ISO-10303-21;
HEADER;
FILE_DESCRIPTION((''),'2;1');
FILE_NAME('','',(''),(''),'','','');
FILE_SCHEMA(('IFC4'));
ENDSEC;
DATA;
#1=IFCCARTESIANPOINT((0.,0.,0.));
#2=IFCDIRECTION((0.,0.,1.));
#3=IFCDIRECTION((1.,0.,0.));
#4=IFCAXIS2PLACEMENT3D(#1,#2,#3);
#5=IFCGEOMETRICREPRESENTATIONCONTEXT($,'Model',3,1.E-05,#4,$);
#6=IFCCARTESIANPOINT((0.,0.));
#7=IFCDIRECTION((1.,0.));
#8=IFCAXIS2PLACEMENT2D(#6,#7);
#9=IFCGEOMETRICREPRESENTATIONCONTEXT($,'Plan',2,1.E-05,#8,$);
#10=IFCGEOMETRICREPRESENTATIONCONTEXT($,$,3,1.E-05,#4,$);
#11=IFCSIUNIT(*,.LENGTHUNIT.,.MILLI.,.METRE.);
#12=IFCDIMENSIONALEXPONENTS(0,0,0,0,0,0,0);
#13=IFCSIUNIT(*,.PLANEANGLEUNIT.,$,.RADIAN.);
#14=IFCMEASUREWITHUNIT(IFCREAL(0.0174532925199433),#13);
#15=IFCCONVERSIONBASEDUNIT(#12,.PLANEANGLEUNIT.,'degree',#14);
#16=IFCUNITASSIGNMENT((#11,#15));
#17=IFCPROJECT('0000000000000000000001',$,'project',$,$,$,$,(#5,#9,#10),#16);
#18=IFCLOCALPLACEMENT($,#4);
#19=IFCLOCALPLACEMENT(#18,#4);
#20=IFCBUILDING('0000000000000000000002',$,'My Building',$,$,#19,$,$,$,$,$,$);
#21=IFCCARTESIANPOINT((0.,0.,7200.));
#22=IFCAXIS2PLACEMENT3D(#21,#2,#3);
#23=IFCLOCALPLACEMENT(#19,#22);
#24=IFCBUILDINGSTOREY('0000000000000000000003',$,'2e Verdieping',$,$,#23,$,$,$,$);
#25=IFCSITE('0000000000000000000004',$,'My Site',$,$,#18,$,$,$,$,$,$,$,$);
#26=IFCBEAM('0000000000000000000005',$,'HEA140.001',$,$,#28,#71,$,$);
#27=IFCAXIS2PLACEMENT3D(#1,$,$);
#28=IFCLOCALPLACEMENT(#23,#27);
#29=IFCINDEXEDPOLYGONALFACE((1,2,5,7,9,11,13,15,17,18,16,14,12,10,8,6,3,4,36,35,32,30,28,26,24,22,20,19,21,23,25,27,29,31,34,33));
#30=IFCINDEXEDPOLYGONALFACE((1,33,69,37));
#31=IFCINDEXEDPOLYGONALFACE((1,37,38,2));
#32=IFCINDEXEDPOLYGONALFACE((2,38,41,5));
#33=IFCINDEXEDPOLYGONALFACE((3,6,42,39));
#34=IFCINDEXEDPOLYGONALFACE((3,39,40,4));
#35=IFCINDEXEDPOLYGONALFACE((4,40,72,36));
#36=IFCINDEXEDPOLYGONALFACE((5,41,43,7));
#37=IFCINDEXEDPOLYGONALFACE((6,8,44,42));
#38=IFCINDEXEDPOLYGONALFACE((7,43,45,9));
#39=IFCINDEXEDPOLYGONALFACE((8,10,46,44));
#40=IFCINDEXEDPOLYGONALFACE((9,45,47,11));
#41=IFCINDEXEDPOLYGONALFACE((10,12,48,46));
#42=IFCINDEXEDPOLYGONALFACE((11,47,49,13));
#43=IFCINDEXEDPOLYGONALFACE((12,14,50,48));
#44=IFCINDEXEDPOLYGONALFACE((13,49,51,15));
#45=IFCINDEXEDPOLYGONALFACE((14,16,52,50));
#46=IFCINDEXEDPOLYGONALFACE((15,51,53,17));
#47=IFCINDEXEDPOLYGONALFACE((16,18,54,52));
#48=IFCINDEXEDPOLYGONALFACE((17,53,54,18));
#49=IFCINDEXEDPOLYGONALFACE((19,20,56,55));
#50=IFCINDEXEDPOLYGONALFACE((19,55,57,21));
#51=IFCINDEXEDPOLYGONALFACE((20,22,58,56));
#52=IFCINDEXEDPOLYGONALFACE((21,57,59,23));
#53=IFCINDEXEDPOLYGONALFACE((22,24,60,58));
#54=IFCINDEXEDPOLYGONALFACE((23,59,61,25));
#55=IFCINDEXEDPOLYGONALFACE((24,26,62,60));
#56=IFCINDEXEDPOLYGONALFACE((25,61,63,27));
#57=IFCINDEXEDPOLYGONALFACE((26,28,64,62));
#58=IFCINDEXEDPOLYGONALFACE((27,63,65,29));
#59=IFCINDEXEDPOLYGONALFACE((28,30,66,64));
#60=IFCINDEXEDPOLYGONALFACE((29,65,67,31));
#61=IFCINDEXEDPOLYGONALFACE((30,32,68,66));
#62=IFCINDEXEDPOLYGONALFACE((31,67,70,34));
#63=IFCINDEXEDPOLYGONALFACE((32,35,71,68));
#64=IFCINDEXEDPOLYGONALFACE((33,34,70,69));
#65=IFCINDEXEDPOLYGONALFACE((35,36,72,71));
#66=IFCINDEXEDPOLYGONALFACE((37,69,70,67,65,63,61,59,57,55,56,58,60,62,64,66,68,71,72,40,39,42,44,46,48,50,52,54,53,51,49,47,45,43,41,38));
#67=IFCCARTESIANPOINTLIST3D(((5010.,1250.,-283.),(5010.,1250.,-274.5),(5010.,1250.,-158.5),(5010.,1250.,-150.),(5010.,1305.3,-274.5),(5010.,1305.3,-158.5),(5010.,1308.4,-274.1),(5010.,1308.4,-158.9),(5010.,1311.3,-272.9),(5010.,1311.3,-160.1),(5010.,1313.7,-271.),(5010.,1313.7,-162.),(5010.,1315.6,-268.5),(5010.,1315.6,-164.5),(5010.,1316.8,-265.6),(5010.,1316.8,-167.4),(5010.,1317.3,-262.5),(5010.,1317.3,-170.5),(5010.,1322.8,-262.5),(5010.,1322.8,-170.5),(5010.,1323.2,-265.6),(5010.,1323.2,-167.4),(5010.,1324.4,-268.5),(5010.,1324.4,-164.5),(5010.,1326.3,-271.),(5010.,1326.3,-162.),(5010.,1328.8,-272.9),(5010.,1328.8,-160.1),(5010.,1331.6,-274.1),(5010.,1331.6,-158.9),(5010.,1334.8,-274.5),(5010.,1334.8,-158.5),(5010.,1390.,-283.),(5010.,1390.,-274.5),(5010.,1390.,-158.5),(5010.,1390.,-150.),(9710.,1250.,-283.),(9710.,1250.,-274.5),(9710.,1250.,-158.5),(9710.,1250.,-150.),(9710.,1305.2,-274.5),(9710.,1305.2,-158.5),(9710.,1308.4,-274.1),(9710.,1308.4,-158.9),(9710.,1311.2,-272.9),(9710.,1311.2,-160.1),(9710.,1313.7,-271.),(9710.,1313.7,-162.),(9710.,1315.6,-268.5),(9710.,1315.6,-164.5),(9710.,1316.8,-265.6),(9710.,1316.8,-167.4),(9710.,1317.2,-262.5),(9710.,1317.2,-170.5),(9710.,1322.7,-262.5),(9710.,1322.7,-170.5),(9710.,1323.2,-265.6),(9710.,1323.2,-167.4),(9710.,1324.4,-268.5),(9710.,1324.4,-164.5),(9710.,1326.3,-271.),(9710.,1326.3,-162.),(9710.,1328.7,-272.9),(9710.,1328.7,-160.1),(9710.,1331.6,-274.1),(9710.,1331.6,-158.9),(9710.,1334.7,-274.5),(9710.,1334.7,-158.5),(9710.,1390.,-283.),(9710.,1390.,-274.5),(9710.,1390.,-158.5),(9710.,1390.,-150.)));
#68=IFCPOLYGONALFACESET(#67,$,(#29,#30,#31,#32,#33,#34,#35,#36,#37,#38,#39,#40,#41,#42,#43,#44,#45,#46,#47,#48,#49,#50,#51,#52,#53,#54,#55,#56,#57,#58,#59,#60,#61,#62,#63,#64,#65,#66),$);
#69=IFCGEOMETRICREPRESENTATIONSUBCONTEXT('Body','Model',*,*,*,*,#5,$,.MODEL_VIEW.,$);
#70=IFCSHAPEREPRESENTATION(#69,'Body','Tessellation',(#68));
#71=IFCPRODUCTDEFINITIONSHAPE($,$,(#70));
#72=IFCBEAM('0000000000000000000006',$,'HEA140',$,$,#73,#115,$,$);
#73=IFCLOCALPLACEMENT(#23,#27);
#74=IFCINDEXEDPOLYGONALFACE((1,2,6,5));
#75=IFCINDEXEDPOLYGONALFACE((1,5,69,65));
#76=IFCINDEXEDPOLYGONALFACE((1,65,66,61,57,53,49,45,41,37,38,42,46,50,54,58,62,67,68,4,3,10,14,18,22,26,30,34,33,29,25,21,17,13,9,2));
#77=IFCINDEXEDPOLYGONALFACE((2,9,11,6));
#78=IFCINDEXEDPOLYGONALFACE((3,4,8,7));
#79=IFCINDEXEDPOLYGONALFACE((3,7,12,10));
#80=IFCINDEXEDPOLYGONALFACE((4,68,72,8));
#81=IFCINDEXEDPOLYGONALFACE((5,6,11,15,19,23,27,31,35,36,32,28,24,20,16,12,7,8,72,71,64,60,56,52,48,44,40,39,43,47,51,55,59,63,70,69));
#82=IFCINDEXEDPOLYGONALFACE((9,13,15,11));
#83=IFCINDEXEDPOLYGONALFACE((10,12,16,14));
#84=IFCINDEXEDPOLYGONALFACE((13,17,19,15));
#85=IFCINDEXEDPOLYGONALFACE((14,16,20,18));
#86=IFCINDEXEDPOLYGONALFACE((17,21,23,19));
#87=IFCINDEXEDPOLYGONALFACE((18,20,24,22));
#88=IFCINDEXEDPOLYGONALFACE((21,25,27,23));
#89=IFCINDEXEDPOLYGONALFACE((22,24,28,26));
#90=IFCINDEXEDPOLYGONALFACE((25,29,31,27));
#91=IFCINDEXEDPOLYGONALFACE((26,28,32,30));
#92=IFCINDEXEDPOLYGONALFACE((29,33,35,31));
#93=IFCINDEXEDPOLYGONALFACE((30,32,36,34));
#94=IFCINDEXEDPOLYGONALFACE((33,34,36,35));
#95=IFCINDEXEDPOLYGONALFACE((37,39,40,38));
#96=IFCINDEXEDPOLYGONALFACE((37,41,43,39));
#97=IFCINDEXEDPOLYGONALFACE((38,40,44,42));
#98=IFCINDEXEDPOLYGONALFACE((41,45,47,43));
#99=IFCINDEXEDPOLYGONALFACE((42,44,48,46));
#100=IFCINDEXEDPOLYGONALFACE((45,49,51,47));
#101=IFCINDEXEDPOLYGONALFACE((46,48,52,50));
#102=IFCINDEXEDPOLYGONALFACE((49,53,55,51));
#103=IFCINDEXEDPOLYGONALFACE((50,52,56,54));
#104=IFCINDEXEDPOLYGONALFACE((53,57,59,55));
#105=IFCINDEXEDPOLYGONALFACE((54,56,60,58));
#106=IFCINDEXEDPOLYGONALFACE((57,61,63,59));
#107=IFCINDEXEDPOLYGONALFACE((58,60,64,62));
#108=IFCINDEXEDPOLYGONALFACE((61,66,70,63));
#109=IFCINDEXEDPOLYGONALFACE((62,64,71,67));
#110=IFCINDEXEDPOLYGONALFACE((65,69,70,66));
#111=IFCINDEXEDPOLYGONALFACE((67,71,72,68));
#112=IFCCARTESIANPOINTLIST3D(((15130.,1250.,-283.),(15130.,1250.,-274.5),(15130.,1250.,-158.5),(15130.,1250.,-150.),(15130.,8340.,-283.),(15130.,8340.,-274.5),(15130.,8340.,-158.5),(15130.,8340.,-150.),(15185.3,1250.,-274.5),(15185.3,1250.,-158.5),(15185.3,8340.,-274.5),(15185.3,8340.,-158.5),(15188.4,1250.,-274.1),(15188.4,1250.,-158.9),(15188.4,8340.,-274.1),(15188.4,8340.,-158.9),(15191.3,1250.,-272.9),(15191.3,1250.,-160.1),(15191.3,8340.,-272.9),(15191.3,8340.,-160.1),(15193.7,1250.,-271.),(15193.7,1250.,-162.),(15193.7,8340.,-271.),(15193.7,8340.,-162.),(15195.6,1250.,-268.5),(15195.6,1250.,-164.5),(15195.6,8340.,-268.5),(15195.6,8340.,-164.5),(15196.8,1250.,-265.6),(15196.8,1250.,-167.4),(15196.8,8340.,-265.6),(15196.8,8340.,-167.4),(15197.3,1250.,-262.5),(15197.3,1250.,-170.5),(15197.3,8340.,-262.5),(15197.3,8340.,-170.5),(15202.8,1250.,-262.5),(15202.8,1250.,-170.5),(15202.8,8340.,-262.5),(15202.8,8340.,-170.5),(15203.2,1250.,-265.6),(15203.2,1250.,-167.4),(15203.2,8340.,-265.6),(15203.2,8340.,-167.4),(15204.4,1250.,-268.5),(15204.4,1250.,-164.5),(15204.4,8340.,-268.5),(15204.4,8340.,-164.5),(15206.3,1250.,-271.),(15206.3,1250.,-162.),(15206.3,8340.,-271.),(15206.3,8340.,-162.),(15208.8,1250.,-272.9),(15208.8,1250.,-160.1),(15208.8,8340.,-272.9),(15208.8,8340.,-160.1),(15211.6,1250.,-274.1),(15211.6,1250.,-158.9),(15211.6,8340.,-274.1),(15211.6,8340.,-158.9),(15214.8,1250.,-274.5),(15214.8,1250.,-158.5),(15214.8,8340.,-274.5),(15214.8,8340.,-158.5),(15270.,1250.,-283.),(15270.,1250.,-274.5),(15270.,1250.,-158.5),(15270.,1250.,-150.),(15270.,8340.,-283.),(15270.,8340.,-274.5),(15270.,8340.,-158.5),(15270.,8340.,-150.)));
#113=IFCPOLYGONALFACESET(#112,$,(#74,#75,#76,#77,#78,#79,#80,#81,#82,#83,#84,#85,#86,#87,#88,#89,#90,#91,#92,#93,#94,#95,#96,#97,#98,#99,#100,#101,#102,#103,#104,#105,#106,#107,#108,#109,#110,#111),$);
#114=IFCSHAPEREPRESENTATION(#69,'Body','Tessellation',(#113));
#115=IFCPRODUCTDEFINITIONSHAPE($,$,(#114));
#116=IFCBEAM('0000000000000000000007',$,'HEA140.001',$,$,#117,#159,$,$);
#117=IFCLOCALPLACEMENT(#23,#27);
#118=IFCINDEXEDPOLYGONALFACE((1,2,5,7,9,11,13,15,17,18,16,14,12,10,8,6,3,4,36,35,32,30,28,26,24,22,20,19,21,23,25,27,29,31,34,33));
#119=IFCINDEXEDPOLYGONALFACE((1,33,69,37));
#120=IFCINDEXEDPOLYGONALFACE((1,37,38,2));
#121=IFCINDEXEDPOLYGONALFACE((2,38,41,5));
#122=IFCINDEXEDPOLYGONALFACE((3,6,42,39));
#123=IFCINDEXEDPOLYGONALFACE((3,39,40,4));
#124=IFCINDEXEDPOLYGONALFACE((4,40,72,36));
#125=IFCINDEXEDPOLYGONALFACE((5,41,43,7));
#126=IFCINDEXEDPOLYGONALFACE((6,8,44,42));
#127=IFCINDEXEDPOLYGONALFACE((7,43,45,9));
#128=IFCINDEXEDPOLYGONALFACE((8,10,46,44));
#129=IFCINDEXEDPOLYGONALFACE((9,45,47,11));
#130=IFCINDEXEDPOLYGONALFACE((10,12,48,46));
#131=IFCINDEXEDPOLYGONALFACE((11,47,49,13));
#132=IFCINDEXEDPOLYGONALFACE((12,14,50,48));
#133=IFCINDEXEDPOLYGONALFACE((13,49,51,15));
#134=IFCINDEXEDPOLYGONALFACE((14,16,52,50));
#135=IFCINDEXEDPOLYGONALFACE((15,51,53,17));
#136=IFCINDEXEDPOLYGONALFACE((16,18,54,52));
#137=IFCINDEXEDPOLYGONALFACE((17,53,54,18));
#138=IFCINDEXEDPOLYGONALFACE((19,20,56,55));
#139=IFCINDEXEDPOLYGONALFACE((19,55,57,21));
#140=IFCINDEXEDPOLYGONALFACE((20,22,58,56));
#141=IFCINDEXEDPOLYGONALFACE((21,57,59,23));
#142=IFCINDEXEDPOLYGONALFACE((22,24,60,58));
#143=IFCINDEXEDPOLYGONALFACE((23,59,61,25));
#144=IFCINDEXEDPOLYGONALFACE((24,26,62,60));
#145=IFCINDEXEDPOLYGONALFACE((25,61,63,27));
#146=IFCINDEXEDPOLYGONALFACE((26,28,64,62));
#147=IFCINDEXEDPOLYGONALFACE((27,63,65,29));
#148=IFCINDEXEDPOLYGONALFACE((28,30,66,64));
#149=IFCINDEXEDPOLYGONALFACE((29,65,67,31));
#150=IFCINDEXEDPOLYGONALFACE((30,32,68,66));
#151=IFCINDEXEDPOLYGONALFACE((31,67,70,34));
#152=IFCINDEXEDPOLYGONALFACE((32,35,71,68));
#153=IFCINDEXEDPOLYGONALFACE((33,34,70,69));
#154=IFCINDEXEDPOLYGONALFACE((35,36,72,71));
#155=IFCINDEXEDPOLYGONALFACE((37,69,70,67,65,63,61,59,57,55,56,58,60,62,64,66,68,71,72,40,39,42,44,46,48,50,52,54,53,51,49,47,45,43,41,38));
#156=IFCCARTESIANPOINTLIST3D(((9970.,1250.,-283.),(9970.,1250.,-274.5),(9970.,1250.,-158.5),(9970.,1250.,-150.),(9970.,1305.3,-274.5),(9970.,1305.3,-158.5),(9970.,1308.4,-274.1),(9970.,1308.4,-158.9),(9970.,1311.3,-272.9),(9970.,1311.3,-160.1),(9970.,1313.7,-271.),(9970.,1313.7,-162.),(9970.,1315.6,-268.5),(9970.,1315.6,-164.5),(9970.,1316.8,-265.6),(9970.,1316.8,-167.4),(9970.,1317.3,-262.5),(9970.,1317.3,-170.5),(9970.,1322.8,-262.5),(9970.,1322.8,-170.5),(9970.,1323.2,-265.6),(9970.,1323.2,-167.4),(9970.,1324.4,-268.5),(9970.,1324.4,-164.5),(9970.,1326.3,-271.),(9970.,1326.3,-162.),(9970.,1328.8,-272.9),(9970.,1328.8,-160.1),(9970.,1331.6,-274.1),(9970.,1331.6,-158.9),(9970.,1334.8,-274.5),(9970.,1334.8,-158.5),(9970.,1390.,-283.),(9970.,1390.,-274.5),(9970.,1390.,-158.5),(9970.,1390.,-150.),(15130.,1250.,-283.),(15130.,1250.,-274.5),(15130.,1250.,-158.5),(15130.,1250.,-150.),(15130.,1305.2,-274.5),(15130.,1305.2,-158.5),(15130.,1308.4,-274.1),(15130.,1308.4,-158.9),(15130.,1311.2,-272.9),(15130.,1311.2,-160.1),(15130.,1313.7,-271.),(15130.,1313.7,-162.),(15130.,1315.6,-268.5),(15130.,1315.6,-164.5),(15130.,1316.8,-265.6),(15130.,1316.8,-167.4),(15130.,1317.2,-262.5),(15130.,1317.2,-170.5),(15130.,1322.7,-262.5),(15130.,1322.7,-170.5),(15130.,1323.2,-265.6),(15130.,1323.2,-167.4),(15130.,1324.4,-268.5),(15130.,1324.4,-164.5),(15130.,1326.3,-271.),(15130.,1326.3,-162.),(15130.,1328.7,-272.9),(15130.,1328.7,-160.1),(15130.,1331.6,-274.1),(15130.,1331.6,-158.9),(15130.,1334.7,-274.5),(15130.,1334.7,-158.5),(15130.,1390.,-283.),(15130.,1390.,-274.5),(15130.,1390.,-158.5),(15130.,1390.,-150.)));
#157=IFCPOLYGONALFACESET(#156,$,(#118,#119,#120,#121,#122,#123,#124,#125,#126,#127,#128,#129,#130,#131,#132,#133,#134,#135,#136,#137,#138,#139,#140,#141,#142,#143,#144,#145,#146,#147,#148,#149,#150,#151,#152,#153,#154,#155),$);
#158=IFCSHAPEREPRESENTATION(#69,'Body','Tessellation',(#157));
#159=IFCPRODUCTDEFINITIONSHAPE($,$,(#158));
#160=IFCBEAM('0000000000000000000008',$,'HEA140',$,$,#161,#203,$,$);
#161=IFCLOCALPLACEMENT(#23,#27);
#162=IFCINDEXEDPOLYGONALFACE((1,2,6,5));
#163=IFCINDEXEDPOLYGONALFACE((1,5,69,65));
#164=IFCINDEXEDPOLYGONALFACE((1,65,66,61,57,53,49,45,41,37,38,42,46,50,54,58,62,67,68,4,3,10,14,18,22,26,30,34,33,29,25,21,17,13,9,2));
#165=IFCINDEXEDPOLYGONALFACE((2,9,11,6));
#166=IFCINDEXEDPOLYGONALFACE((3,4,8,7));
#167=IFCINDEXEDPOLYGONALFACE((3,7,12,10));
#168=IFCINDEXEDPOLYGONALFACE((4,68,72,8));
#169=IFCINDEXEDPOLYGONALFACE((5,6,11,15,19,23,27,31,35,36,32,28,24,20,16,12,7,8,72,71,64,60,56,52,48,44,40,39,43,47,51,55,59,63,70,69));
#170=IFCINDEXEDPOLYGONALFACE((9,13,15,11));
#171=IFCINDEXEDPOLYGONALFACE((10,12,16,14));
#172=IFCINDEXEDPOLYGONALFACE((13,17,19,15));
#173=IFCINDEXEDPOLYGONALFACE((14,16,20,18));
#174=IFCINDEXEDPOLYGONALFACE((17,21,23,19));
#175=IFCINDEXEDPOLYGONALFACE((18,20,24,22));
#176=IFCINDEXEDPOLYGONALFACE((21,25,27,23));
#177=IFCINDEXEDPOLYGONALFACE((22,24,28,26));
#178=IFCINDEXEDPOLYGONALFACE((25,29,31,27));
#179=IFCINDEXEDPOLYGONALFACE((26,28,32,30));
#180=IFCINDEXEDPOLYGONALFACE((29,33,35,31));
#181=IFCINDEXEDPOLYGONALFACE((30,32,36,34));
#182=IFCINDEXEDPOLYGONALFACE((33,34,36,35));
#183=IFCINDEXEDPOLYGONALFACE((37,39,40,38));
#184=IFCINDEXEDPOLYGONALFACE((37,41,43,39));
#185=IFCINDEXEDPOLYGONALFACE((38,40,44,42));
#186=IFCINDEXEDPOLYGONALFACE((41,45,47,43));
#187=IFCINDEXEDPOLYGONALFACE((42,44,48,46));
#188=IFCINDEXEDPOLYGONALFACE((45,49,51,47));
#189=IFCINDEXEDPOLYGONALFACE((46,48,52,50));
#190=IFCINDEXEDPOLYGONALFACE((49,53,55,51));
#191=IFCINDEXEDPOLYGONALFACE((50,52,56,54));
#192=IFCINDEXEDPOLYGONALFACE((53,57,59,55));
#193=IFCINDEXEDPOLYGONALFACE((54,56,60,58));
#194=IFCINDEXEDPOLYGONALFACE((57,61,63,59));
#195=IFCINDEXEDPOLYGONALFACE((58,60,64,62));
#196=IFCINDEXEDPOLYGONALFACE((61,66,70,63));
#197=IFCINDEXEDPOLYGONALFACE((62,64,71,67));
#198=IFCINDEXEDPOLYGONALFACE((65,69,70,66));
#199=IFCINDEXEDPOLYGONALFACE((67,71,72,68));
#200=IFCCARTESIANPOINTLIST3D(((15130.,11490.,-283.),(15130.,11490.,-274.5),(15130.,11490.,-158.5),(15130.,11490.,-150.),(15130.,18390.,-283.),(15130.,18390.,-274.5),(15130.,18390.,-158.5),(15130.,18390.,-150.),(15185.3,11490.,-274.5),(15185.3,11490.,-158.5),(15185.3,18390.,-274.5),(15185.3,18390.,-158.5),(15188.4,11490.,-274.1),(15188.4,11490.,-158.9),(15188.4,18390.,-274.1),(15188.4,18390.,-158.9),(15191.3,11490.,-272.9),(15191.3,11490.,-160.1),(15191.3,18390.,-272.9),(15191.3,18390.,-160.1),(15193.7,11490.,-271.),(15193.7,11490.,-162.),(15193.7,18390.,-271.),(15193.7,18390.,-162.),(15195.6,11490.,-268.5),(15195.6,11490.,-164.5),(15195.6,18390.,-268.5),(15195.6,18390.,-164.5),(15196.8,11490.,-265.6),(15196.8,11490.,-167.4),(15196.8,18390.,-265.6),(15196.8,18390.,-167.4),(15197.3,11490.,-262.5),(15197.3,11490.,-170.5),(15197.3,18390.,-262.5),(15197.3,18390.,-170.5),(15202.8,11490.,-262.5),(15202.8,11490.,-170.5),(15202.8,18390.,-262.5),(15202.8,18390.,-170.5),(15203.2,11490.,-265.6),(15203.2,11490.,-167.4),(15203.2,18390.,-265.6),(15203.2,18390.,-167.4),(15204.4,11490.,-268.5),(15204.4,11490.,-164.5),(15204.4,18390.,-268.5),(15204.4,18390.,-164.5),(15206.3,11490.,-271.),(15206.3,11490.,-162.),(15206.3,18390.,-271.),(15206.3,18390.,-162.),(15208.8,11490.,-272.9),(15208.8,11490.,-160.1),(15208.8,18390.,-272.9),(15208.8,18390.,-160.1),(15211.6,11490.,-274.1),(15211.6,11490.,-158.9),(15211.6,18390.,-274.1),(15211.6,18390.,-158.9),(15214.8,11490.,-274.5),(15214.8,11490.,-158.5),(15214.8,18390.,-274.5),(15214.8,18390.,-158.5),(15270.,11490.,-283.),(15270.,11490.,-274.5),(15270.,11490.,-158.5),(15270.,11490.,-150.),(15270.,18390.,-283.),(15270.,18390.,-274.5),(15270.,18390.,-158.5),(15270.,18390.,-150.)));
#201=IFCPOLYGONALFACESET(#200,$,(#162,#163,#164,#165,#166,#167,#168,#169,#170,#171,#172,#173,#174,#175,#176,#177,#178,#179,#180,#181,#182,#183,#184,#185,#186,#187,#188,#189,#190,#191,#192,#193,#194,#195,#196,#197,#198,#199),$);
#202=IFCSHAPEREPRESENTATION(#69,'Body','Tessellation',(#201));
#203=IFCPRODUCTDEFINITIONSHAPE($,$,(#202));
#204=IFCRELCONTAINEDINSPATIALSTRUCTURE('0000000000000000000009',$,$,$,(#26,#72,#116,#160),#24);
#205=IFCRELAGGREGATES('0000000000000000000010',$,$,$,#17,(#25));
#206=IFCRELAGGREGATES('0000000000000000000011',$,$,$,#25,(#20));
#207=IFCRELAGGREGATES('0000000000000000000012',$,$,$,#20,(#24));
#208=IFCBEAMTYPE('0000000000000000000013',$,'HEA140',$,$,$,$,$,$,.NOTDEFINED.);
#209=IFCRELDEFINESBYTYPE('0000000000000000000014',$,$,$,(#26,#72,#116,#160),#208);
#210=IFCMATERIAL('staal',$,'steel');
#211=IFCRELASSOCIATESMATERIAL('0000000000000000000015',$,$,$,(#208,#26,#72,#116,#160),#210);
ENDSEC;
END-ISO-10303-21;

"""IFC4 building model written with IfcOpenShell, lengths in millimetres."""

from ifc_helpers import new_model, entity, si_unit, converted_unit, frame, origin_with_axes, origin_2d_with_axis, place, context, subcontext, project, spatial, i_section, extrude, material, material_profile, profile_set, profile_usage, type_object, element, save


model = new_model("IFC4")

# Units and contexts
model_context = context("Model", 3, precision=1e-05, world=origin_with_axes())
plan_context = context("Plan", 2, precision=1e-05, world=origin_2d_with_axis())
context_of_model = context(None, 3, precision=1e-05, world=origin_with_axes())
body_context = subcontext(model_context, "Body", "Model", "MODEL_VIEW")
ifc_project = project(units=[si_unit("LENGTHUNIT", "METRE", prefix="MILLI"), converted_unit("PLANEANGLEUNIT", "degree", entity("IfcReal", 0.0174532925199433), si_unit("PLANEANGLEUNIT", "RADIAN"), dimensions=[0, 0, 0, 0, 0, 0, 0])], contexts=[model_context, plan_context, context_of_model])

# Site, building, storey
site_placement = place(None, origin_with_axes())
site = spatial("IfcSite", under=ifc_project, at=site_placement, Name="My Site")
building_placement = place(site_placement, origin_with_axes())
building = spatial("IfcBuilding", under=site, at=building_placement, Name="My Building")
storey_placement = place(building_placement, frame((0.0, 0.0, 7200.0), z_axis=(0.0, 0.0, 1.0), x_axis=(1.0, 0.0, 0.0)))
storey = spatial("IfcBuildingStorey", under=building, at=storey_placement, Name="2e Verdieping")

# Beams
ifc_material_1 = material(Name="staal", Category="steel")
ifc_material_profile_1 = material_profile(ifc_material_1, i_section(OverallWidth=140.0, OverallDepth=133.0, WebThickness=5.5, FlangeThickness=8.5, FilletRadius=12.0))
ifc_profile_set_1 = profile_set([ifc_material_profile_1], Name="HEA140")
beam_type_1 = type_object("IfcBeamType", Name="HEA140", PredefinedType="NOTDEFINED", material=ifc_profile_set_1)
ifc_profile_usage_1 = profile_usage(ifc_profile_set_1)
beam_1_placement = place(storey_placement, frame((5010.0, 1320.0, -216.5), z_axis=(1.0, 0.0, 0.0), x_axis=(0.0, 1.0, 0.0)))
element("IfcBeam", 1, at=beam_1_placement, inside=storey, type_object=beam_type_1, material=ifc_profile_usage_1, Name="HEA140.001", context=body_context, shape_type="SweptSolid", body=[
    extrude(i_section(OverallWidth=140.0, OverallDepth=133.0, WebThickness=5.5, FlangeThickness=8.5, FilletRadius=12.0), origin_with_axes(), (0.0, 0.0, 1.0), 4700.0),
])
ifc_profile_usage_2 = profile_usage(ifc_profile_set_1)
beam_2_placement = place(storey_placement, frame((15200.0, 1250.0, -216.5), z_axis=(0.0, 1.0, 0.0), x_axis=(-1.0, 0.0, 0.0)))
element("IfcBeam", 2, at=beam_2_placement, inside=storey, type_object=beam_type_1, material=ifc_profile_usage_2, Name="HEA140", context=body_context, shape_type="SweptSolid", body=[
    extrude(i_section(OverallWidth=140.0, OverallDepth=133.0, WebThickness=5.5, FlangeThickness=8.5, FilletRadius=12.0), origin_with_axes(), (0.0, 0.0, 1.0), 7090.0),
])
ifc_profile_usage_3 = profile_usage(ifc_profile_set_1)
beam_3_placement = place(storey_placement, frame((9970.0, 1320.0, -216.5), z_axis=(1.0, 0.0, 0.0), x_axis=(0.0, 1.0, 0.0)))
element("IfcBeam", 3, at=beam_3_placement, inside=storey, type_object=beam_type_1, material=ifc_profile_usage_3, Name="HEA140.001", context=body_context, shape_type="SweptSolid", body=[
    extrude(i_section(OverallWidth=140.0, OverallDepth=133.0, WebThickness=5.5, FlangeThickness=8.5, FilletRadius=12.0), origin_with_axes(), (0.0, 0.0, 1.0), 5160.0),
])
ifc_profile_usage_4 = profile_usage(ifc_profile_set_1)
beam_4_placement = place(storey_placement, frame((15200.0, 11490.0, -216.5), z_axis=(0.0, 1.0, 0.0), x_axis=(-1.0, 0.0, 0.0)))
element("IfcBeam", 4, at=beam_4_placement, inside=storey, type_object=beam_type_1, material=ifc_profile_usage_4, Name="HEA140", context=body_context, shape_type="SweptSolid", body=[
    extrude(i_section(OverallWidth=140.0, OverallDepth=133.0, WebThickness=5.5, FlangeThickness=8.5, FilletRadius=12.0), origin_with_axes(), (0.0, 0.0, 1.0), 6900.0),
])

save(model, "model.ifc")
